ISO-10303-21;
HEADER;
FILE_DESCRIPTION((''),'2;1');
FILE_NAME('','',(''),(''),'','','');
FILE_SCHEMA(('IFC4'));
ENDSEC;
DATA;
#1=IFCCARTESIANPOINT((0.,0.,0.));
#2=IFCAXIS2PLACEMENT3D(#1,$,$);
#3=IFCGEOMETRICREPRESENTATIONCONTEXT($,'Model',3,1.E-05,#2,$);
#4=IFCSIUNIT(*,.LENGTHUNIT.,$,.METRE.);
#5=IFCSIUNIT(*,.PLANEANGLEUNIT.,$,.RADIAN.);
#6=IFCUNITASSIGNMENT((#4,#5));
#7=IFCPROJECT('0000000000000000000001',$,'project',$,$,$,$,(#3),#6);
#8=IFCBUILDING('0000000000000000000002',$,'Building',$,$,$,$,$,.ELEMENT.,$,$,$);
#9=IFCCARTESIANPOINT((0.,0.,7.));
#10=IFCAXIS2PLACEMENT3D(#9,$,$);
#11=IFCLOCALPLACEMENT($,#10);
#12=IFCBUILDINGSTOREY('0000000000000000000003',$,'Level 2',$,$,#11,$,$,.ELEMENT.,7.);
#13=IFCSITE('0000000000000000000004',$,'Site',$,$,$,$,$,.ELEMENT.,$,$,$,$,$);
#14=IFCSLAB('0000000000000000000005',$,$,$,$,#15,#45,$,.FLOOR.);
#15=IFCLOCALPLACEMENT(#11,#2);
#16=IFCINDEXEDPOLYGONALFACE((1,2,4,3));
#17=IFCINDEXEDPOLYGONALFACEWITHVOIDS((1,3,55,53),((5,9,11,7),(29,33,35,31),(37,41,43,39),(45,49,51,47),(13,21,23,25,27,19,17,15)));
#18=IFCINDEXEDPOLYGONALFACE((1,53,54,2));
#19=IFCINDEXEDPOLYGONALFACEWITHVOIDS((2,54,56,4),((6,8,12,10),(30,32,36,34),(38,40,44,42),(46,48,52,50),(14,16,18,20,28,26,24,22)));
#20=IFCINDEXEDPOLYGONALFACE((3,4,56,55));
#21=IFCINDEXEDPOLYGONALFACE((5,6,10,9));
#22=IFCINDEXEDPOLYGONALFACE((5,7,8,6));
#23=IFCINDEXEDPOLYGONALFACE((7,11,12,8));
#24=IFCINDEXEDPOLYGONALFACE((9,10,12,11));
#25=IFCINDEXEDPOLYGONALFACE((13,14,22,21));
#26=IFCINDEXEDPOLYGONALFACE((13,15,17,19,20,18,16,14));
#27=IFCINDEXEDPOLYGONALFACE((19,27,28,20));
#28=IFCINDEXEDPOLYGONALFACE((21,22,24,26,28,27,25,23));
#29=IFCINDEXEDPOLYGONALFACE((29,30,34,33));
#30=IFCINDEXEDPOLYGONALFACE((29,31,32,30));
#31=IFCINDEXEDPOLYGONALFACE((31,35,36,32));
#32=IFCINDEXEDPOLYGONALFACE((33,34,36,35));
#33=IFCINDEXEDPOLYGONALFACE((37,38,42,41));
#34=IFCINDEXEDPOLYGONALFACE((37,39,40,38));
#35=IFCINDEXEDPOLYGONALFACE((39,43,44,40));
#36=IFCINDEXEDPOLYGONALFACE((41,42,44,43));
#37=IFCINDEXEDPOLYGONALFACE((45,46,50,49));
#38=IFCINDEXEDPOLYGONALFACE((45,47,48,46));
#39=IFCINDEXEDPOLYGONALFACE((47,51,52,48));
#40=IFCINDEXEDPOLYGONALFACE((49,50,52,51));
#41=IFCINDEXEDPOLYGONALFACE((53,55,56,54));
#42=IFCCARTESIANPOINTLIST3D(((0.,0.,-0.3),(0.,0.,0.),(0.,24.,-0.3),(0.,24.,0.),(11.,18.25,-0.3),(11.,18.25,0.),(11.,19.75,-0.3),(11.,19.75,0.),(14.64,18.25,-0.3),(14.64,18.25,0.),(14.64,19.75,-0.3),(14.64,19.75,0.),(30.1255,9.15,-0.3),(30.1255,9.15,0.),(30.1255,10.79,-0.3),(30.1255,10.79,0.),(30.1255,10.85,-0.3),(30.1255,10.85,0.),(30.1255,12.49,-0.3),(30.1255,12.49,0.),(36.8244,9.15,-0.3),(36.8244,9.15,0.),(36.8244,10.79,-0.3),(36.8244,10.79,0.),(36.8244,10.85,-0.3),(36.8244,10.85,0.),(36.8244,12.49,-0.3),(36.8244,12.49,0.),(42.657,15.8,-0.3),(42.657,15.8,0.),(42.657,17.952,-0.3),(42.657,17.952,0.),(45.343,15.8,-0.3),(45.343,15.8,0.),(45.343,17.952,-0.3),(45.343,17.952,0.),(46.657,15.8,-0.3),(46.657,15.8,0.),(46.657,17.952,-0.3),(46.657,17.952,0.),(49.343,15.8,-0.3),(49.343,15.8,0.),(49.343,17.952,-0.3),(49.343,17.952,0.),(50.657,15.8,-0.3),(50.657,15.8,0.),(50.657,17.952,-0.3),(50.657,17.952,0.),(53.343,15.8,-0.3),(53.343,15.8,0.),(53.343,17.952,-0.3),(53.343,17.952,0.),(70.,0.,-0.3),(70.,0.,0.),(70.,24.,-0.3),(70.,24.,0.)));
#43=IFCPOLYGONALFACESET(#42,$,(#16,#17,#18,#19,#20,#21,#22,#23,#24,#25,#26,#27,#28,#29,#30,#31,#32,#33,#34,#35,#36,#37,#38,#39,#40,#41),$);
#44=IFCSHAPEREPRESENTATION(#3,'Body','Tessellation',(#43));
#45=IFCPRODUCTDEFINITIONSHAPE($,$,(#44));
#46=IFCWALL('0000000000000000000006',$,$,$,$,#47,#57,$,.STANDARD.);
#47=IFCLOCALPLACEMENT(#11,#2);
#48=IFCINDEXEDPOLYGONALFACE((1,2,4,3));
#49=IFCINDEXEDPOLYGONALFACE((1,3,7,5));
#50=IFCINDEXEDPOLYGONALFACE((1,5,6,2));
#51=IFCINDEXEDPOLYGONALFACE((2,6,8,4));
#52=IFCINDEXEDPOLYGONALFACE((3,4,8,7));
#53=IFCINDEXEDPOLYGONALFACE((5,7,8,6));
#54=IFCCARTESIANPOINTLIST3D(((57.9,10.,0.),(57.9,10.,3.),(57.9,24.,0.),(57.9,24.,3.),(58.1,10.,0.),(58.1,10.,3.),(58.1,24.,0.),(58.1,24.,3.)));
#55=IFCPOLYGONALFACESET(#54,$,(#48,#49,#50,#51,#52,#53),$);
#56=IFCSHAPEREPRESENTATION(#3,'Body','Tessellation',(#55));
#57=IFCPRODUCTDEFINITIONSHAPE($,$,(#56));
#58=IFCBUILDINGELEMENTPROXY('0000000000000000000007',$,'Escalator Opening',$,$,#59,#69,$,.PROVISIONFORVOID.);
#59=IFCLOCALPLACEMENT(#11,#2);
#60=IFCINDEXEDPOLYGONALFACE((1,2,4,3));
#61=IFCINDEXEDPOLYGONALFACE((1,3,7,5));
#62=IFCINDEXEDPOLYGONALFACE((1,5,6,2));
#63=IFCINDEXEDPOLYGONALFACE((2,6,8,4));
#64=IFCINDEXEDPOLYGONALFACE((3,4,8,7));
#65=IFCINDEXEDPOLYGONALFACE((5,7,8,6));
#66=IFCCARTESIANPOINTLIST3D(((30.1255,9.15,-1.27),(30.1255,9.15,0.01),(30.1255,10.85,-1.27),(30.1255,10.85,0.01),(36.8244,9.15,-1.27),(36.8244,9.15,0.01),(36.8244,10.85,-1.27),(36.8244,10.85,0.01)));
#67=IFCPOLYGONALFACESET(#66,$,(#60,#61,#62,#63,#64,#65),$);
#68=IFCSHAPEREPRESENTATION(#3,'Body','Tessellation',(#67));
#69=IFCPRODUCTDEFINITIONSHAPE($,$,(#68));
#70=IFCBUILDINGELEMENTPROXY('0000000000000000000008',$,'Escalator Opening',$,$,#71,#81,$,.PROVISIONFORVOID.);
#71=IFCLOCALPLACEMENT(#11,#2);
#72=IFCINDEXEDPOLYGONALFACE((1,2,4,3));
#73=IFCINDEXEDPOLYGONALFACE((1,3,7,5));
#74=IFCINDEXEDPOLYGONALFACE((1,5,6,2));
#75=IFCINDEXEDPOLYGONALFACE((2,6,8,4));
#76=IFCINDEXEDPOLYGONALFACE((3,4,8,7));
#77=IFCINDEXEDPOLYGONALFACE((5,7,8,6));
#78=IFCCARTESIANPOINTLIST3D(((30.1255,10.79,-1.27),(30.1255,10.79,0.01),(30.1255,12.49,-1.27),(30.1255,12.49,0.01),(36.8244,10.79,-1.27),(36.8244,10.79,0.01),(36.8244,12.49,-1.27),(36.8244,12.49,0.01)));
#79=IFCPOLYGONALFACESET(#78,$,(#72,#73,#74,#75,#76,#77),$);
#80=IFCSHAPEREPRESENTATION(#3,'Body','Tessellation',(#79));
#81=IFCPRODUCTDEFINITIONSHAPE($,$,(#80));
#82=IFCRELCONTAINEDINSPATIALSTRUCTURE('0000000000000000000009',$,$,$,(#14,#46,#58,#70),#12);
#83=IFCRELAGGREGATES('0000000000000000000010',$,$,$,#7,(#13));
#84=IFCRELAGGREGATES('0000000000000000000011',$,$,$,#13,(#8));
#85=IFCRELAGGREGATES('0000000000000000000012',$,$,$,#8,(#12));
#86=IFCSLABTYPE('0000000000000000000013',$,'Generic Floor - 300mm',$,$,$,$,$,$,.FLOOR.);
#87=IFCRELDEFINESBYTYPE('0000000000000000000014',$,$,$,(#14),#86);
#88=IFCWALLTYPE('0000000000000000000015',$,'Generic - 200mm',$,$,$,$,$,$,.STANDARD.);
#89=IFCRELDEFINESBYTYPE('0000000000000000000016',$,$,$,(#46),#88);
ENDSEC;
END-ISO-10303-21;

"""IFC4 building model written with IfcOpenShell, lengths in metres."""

from ifc_helpers import new_model, si_unit, frame, frame_2d, origin, place, context, project, spatial, polyline, rectangle, outline, extrude, type_object, element, save


model = new_model("IFC4")

# Units and contexts
model_context = context("Model", 3, precision=1e-05, world=origin())
ifc_project = project(units=[si_unit("LENGTHUNIT", "METRE"), si_unit("PLANEANGLEUNIT", "RADIAN")], contexts=[model_context])

# Site, building, storey
site = spatial("IfcSite", under=ifc_project, Name="Site", CompositionType="ELEMENT")
building = spatial("IfcBuilding", under=site, Name="Building", CompositionType="ELEMENT")
storey_placement = place(None, frame((0.0, 0.0, 7.0)))
storey = spatial("IfcBuildingStorey", under=building, at=storey_placement, Name="Level 2", CompositionType="ELEMENT", Elevation=7.0)

# Slab, openings
slab_type = type_object("IfcSlabType", Name="Generic Floor - 300mm", PredefinedType="FLOOR")
slab_placement = place(None, frame((0.0, 0.0, 7.0)))
slab = element("IfcSlab", 1, at=slab_placement, inside=storey, type_object=slab_type, PredefinedType="FLOOR", context=model_context, shape_type="SweptSolid", body=[
    extrude(outline(polyline([(0.0, 0.0), (70.0, 0.0), (70.0, 24.0), (0.0, 24.0), (0.0, 0.0)])), origin(), (0.0, 0.0, -1.0), 0.3),
])
opening_1_placement = place(None, frame((0.0, 0.0, 7.001)))
element("IfcOpeningElement", 2, at=opening_1_placement, cuts=slab, PredefinedType="OPENING", context=model_context, shape_type="SweptSolid", body=[
    extrude(outline(polyline([(11.0, 19.75), (11.0, 18.25), (14.64, 18.25), (14.64, 19.75), (11.0, 19.75)])), origin(), (0.0, 0.0, -1.0), 0.302),
])
opening_2_placement = place(None, frame((0.0, 0.0, 7.001)))
element("IfcOpeningElement", 3, at=opening_2_placement, cuts=slab, PredefinedType="OPENING", context=model_context, shape_type="SweptSolid", body=[
    extrude(outline(polyline([(30.1255, 9.15), (36.8244, 9.15), (36.8244, 10.85), (30.1255, 10.85), (30.1255, 9.15)])), origin(), (0.0, 0.0, -1.0), 0.302),
])
opening_3_placement = place(None, frame((0.0, 0.0, 7.001)))
element("IfcOpeningElement", 4, at=opening_3_placement, cuts=slab, PredefinedType="OPENING", context=model_context, shape_type="SweptSolid", body=[
    extrude(outline(polyline([(30.1255, 10.79), (36.8244, 10.79), (36.8244, 12.49), (30.1255, 12.49), (30.1255, 10.79)])), origin(), (0.0, 0.0, -1.0), 0.302),
])
opening_4_placement = place(None, frame((0.0, 0.0, 7.001)))
element("IfcOpeningElement", 5, at=opening_4_placement, cuts=slab, PredefinedType="OPENING", context=model_context, shape_type="SweptSolid", body=[
    extrude(outline(polyline([(42.657, 15.8), (45.343, 15.8), (45.343, 17.952), (42.657, 17.952), (42.657, 15.8)])), origin(), (0.0, 0.0, -1.0), 0.302),
])
opening_5_placement = place(None, frame((0.0, 0.0, 7.001)))
element("IfcOpeningElement", 6, at=opening_5_placement, cuts=slab, PredefinedType="OPENING", context=model_context, shape_type="SweptSolid", body=[
    extrude(outline(polyline([(46.657, 15.8), (49.343, 15.8), (49.343, 17.952), (46.657, 17.952), (46.657, 15.8)])), origin(), (0.0, 0.0, -1.0), 0.302),
])
opening_6_placement = place(None, frame((0.0, 0.0, 7.001)))
element("IfcOpeningElement", 7, at=opening_6_placement, cuts=slab, PredefinedType="OPENING", context=model_context, shape_type="SweptSolid", body=[
    extrude(outline(polyline([(50.657, 15.8), (53.343, 15.8), (53.343, 17.952), (50.657, 17.952), (50.657, 15.8)])), origin(), (0.0, 0.0, -1.0), 0.302),
])

# Wall
wall_type = type_object("IfcWallType", Name="Generic - 200mm", PredefinedType="STANDARD")
wall_placement = place(None, frame((58.0, 10.0, 7.0), z_axis=(0.0, 0.0, 1.0), x_axis=(0.0, 1.0, 0.0)))
element("IfcWall", 8, at=wall_placement, inside=storey, type_object=wall_type, PredefinedType="STANDARD", context=model_context, shape_type="SweptSolid", body=[
    extrude(rectangle(XDim=14.0, YDim=0.2, at=frame_2d((7.0, 0.0))), origin(), (0.0, 0.0, 1.0), 3.0),
])

# Building element proxies
proxy_1_placement = place(None, frame((0.0, 0.0, 7.01)))
element("IfcBuildingElementProxy", 9, at=proxy_1_placement, inside=storey, Name="Escalator Opening", PredefinedType="PROVISIONFORVOID", context=model_context, shape_type="SweptSolid", body=[
    extrude(outline(polyline([(30.1255, 9.15), (36.8244, 9.15), (36.8244, 10.85), (30.1255, 10.85), (30.1255, 9.15)])), origin(), (0.0, 0.0, -1.0), 1.28),
])
proxy_2_placement = place(None, frame((0.0, 0.0, 7.01)))
element("IfcBuildingElementProxy", 10, at=proxy_2_placement, inside=storey, Name="Escalator Opening", PredefinedType="PROVISIONFORVOID", context=model_context, shape_type="SweptSolid", body=[
    extrude(outline(polyline([(30.1255, 10.79), (36.8244, 10.79), (36.8244, 12.49), (30.1255, 12.49), (30.1255, 10.79)])), origin(), (0.0, 0.0, -1.0), 1.28),
])

save(model, "model.ifc")
